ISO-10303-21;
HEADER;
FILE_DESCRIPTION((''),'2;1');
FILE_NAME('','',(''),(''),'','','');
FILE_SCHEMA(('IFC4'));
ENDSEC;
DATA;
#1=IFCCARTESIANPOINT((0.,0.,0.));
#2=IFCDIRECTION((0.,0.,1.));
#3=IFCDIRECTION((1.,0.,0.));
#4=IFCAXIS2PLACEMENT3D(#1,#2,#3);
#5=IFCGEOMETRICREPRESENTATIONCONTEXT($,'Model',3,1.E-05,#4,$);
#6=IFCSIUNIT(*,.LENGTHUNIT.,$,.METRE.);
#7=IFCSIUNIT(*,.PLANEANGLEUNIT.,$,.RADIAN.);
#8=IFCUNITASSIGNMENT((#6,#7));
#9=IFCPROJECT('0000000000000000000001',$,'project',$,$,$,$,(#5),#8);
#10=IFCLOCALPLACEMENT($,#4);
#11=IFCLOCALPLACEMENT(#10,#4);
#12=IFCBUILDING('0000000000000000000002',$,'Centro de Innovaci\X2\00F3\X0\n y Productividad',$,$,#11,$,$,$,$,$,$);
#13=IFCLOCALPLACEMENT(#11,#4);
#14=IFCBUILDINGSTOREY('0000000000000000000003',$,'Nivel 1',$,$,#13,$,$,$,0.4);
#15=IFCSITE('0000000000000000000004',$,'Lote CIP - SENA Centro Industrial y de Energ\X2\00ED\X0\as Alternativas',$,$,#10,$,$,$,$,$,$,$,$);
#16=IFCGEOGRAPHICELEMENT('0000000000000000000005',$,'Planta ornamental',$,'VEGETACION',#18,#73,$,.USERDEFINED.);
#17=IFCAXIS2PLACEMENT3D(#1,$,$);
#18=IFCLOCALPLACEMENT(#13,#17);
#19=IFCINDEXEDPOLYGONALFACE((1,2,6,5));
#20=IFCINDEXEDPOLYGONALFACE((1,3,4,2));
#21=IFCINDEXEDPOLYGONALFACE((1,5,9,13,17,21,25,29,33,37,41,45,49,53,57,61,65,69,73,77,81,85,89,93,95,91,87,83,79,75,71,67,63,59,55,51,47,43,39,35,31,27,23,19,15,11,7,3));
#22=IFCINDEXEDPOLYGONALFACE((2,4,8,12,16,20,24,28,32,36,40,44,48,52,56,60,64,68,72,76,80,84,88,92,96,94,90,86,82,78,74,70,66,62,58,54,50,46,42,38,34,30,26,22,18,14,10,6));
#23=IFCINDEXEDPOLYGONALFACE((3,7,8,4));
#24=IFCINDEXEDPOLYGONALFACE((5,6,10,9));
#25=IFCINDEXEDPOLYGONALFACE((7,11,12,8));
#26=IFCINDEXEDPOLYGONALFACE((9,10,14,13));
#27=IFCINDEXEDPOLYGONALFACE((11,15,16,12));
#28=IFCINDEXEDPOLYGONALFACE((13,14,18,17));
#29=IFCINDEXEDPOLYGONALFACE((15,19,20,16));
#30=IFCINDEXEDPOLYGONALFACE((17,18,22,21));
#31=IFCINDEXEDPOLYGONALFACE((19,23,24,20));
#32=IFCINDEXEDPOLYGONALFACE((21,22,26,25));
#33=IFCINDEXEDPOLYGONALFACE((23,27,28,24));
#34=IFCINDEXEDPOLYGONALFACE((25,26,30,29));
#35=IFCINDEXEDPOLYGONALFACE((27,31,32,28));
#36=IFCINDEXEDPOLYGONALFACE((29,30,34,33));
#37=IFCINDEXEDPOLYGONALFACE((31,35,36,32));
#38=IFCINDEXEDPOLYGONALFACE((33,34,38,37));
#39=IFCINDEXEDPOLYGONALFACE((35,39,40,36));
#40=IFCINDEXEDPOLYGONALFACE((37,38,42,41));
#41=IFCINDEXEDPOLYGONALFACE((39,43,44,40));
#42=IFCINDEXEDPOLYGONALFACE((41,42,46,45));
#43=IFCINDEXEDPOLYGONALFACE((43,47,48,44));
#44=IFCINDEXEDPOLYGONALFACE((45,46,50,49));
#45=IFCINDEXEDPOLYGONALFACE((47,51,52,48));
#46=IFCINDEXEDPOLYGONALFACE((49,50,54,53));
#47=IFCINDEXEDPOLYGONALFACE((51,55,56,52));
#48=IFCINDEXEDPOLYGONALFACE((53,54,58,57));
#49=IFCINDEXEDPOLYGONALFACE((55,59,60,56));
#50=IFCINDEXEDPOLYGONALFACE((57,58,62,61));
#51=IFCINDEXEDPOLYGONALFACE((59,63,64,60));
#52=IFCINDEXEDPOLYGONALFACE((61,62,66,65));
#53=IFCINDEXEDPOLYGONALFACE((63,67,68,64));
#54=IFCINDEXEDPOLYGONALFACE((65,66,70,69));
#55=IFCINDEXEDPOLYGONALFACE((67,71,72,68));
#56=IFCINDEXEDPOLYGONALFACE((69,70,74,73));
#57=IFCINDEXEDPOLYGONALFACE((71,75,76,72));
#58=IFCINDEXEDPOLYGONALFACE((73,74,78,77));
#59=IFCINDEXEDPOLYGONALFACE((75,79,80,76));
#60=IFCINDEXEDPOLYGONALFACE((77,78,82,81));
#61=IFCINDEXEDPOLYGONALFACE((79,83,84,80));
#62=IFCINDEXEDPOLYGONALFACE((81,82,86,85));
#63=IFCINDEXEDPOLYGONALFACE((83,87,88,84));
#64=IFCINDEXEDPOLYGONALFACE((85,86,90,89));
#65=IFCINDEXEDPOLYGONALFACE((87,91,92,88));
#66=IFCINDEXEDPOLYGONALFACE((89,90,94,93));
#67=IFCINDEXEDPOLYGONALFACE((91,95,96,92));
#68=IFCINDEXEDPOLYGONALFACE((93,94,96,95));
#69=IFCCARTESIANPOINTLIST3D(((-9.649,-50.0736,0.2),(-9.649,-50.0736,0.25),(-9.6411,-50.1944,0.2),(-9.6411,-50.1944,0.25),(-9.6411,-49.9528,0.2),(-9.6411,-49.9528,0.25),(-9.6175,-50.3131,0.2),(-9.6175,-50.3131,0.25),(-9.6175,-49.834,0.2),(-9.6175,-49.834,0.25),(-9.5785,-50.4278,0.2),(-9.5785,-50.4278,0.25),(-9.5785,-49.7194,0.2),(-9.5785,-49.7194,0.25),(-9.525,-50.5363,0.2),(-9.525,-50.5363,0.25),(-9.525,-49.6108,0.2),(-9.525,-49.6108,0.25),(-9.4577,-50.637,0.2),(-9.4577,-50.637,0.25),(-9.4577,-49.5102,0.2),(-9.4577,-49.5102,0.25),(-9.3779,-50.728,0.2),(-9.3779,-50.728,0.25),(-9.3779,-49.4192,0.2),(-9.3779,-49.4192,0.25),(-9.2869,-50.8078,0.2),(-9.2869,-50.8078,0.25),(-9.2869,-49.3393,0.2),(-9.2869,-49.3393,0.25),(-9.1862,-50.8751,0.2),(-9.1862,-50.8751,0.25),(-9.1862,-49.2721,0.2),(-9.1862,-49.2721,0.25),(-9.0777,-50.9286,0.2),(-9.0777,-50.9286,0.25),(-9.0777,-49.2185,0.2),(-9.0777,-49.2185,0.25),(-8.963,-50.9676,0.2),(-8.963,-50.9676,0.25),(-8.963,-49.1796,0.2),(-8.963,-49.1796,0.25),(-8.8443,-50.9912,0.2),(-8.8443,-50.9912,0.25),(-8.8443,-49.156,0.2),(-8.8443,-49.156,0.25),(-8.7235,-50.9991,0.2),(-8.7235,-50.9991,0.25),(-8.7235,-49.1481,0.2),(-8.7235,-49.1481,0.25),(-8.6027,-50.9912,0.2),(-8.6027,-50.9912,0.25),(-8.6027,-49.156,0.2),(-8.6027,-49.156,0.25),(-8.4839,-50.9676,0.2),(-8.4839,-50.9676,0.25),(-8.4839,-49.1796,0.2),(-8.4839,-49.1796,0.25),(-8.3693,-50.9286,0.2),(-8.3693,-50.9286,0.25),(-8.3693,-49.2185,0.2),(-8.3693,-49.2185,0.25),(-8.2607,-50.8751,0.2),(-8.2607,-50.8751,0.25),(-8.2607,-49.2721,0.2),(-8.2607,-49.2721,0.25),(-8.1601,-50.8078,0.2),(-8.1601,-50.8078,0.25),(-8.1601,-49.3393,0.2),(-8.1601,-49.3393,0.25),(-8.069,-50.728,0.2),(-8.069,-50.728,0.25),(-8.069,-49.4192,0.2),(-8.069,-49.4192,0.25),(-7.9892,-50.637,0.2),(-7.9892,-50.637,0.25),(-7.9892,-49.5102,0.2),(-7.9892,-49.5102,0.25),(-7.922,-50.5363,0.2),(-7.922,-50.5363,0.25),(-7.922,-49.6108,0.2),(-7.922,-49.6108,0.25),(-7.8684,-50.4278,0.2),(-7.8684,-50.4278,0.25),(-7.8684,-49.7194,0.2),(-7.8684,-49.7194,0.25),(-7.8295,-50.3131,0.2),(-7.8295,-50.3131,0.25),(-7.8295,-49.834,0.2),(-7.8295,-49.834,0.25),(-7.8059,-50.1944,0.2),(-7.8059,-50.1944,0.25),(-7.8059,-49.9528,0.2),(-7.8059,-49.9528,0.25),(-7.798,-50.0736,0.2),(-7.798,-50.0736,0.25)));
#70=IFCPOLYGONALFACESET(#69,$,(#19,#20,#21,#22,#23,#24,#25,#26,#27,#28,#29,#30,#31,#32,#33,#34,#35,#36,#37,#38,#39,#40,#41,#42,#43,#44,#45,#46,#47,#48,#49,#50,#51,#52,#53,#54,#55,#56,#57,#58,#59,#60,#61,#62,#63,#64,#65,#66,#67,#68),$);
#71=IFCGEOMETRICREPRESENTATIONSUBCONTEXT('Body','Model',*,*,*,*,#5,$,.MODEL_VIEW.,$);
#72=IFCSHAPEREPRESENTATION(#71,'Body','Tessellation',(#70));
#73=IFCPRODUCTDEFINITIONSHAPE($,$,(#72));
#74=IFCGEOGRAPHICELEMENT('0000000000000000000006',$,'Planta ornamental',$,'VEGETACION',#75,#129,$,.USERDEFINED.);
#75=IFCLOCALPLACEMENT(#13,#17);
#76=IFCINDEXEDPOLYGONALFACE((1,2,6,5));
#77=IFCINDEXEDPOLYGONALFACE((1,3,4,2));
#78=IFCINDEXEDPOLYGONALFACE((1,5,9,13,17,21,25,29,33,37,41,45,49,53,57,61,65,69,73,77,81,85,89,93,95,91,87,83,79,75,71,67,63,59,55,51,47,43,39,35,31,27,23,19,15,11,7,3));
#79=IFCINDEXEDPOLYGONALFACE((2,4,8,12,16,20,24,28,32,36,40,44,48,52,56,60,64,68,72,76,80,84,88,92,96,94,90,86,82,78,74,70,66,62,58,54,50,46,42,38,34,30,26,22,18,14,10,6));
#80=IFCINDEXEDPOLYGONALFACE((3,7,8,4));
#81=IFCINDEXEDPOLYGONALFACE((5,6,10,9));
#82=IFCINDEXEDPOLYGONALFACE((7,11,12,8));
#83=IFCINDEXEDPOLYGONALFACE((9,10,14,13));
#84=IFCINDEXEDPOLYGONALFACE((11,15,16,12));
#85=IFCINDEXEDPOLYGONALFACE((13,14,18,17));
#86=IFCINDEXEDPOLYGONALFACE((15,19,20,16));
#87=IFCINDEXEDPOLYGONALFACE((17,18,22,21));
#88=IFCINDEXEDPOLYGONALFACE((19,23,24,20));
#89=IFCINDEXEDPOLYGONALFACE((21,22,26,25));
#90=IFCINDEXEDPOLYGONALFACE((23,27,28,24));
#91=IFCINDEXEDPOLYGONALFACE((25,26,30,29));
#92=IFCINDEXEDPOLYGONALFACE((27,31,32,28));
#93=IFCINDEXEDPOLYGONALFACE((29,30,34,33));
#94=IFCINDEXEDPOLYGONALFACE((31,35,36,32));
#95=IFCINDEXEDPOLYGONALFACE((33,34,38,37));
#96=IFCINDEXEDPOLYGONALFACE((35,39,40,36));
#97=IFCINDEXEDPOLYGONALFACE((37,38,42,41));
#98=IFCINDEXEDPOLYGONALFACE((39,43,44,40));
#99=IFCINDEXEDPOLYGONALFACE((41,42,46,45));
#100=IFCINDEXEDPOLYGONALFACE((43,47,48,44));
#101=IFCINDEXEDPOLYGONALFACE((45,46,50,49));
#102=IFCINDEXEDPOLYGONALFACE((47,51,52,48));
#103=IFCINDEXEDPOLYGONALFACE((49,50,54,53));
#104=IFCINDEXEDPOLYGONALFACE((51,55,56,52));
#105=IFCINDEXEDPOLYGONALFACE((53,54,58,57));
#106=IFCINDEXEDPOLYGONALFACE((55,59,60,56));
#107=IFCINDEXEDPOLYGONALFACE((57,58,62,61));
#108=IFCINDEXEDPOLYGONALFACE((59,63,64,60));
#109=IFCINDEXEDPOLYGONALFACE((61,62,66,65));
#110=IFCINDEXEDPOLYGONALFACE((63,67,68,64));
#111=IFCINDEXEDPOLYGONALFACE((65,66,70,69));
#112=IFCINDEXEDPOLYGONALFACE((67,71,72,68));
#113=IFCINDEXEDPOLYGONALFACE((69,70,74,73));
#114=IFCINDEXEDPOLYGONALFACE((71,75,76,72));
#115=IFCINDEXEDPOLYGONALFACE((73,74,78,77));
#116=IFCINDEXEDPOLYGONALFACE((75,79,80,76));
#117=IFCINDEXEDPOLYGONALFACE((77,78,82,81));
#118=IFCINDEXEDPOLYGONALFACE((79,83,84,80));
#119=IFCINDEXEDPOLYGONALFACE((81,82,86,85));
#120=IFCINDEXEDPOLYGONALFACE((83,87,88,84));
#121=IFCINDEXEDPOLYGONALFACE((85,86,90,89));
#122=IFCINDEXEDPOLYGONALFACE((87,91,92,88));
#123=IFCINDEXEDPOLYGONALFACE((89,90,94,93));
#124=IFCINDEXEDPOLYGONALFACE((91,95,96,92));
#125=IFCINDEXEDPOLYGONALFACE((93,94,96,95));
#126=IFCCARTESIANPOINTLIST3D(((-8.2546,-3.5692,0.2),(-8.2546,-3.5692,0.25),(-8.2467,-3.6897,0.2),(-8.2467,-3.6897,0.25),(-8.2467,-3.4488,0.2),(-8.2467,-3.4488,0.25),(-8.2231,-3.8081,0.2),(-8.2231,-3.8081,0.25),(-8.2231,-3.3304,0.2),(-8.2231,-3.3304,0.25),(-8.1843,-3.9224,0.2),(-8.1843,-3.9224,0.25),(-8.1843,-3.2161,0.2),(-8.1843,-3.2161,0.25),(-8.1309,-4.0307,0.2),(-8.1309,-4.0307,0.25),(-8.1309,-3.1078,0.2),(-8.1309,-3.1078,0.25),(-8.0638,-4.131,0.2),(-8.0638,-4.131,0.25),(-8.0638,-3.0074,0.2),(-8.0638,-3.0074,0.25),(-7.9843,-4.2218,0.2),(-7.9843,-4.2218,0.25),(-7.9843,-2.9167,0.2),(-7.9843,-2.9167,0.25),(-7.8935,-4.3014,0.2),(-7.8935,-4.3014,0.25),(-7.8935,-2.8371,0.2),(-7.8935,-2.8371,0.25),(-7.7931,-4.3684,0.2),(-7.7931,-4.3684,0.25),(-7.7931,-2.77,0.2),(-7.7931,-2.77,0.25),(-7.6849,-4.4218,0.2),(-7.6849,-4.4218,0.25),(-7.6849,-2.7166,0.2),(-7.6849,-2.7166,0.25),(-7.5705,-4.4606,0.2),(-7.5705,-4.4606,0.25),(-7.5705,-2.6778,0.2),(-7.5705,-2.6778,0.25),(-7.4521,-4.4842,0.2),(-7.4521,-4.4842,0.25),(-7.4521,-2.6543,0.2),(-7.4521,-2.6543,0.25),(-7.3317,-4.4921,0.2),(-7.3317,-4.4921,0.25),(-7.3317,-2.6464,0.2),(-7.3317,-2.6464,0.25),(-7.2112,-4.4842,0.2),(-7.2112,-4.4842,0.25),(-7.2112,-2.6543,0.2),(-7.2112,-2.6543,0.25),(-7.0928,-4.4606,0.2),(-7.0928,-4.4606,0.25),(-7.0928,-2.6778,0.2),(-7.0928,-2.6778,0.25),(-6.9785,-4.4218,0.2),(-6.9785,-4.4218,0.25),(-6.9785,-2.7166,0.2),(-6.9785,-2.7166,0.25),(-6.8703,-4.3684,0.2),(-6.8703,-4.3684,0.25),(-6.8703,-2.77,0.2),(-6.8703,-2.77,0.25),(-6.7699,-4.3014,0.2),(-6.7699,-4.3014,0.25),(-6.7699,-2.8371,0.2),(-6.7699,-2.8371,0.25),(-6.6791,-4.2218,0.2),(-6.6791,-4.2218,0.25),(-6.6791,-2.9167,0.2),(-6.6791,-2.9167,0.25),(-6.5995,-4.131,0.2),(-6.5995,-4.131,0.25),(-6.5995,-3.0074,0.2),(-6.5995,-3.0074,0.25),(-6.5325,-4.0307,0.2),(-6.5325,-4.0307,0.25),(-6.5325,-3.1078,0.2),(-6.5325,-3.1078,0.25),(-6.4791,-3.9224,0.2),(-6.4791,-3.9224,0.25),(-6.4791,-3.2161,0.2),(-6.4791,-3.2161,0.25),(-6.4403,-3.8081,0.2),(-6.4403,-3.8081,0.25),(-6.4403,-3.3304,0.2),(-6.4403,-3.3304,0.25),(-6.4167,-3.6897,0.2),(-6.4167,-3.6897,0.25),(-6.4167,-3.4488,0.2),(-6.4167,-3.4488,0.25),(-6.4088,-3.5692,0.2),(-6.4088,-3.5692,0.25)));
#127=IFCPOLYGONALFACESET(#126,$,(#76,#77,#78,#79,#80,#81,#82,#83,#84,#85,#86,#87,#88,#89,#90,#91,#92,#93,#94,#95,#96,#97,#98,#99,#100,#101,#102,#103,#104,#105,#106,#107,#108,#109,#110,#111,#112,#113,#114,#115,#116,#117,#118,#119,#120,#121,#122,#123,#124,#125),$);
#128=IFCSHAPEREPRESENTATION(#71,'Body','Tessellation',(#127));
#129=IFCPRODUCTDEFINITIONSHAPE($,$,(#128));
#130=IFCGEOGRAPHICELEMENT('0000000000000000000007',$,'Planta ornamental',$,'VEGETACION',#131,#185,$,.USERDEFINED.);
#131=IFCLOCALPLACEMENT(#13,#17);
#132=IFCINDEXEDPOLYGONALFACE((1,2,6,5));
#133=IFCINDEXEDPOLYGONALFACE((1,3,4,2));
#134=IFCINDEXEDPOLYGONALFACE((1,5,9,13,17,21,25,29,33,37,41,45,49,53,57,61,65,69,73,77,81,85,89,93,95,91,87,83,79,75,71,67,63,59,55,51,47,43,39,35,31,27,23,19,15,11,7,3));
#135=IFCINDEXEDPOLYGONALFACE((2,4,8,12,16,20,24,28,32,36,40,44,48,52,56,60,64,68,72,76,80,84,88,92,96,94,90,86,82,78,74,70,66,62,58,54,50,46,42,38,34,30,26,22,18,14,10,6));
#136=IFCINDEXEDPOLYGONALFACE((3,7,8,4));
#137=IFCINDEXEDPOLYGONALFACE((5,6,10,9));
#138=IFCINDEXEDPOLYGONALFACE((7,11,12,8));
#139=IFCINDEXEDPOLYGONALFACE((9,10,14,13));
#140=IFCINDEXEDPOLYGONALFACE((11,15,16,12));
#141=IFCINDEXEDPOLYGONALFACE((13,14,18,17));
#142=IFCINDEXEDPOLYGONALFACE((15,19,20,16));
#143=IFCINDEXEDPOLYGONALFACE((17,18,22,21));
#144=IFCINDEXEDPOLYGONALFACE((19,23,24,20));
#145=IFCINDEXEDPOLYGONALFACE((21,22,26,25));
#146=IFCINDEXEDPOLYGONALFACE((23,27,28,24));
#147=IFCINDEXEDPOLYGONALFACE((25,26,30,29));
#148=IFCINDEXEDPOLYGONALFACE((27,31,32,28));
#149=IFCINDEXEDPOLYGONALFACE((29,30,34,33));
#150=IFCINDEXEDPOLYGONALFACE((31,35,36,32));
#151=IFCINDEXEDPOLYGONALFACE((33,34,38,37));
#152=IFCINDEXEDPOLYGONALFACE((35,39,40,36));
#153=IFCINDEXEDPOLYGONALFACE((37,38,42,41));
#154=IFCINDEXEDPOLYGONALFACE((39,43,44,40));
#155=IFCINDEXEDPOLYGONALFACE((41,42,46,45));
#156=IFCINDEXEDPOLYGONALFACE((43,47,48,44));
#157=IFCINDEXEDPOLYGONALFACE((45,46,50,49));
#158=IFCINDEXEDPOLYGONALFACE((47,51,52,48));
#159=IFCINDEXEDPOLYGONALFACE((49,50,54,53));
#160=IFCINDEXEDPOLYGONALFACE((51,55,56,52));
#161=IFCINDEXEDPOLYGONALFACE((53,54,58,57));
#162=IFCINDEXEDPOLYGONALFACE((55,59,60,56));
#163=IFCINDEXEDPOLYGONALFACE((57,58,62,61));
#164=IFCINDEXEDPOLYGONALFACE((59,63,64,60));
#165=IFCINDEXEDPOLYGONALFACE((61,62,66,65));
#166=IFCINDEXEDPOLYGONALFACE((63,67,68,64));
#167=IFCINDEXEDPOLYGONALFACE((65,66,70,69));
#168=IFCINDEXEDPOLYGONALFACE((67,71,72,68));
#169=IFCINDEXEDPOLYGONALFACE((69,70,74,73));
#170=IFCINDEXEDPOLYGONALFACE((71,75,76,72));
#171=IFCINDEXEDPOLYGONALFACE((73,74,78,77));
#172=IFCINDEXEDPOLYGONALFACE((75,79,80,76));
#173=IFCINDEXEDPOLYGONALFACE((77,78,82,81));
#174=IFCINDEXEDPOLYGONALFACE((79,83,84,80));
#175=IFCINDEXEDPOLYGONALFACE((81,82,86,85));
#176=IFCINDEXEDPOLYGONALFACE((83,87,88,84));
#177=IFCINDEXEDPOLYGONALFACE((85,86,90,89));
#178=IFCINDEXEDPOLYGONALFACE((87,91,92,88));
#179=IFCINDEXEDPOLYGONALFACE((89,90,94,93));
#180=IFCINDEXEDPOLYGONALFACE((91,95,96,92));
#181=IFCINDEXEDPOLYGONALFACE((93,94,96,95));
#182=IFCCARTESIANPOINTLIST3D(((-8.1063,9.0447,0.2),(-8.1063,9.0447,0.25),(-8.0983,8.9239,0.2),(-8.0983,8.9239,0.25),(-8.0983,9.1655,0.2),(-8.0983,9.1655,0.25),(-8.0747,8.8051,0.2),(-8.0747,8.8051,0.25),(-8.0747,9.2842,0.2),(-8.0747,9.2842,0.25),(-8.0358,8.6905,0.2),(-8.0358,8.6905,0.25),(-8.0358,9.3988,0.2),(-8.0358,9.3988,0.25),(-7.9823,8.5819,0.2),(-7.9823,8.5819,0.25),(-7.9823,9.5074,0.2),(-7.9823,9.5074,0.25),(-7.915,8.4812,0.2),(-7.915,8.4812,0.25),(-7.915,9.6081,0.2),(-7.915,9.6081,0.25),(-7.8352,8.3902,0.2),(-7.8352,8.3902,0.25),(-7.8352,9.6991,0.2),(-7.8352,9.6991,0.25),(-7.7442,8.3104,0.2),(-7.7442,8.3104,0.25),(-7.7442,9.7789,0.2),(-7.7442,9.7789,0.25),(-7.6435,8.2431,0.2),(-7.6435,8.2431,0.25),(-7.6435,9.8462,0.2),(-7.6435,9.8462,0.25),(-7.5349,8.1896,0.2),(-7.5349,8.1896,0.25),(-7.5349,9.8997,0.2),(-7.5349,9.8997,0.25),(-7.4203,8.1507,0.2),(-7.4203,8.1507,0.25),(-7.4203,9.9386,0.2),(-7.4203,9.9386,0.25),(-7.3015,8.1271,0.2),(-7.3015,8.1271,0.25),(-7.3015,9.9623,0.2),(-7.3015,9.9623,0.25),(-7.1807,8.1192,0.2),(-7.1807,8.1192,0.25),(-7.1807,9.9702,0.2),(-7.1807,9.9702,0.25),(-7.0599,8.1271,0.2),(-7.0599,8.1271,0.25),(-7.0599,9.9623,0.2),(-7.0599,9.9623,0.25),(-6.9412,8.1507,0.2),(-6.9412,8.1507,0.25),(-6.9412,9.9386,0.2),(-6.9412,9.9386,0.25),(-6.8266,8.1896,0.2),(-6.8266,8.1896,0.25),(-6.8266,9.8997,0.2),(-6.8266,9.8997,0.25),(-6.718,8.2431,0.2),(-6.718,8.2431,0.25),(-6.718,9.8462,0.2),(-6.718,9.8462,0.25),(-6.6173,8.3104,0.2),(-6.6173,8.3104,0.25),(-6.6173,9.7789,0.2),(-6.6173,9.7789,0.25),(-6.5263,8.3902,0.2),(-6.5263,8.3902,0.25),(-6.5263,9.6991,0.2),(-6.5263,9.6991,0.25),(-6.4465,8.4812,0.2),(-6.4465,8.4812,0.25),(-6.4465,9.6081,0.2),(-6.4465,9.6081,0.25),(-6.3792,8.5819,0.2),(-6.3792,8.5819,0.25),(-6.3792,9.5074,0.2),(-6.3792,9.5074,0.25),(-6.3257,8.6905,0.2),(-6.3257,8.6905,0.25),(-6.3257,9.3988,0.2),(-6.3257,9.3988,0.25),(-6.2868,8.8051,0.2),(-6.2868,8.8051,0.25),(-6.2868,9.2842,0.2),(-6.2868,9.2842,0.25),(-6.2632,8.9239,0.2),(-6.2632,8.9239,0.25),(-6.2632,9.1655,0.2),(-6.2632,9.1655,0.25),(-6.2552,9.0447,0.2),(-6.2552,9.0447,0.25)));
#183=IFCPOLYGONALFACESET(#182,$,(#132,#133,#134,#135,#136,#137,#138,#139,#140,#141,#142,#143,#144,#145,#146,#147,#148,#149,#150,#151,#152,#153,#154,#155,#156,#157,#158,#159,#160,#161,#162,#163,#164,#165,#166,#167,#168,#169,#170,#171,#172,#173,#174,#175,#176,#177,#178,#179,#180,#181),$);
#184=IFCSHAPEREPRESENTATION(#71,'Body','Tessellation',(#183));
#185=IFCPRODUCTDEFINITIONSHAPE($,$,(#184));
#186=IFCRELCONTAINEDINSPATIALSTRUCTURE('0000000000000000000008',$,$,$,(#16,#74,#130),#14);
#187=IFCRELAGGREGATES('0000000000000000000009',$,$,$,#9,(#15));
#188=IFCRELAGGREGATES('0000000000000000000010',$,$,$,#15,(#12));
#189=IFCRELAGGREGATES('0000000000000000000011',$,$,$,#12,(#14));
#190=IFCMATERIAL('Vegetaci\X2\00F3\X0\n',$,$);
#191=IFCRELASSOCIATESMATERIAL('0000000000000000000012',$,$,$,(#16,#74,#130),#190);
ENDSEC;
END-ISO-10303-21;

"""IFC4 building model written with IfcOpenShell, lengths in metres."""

from ifc_helpers import new_model, si_unit, frame, origin_with_axes, place, context, subcontext, project, spatial, polyline, outline, extrude, material, element, save


model = new_model("IFC4")

# Units and contexts
model_context = context("Model", 3, precision=1e-05, world=origin_with_axes())
body_context = subcontext(model_context, "Body", "Model", "MODEL_VIEW")
ifc_project = project(units=[si_unit("LENGTHUNIT", "METRE"), si_unit("PLANEANGLEUNIT", "RADIAN")], contexts=[model_context])

# Site, building, storey
site_placement = place(None, origin_with_axes())
site = spatial("IfcSite", under=ifc_project, at=site_placement, Name="Lote CIP - SENA Centro Industrial y de Energías Alternativas")
building_placement = place(site_placement, origin_with_axes())
building = spatial("IfcBuilding", under=site, at=building_placement, Name="Centro de Innovación y Productividad")
storey_placement = place(building_placement, origin_with_axes())
storey = spatial("IfcBuildingStorey", under=building, at=storey_placement, Name="Nivel 1", Elevation=0.4)

# Geographic elements
ifc_material = material(Name="Vegetación")
geographic_element_1_placement = place(storey_placement, origin_with_axes())
element("IfcGeographicElement", 1, at=geographic_element_1_placement, inside=storey, material=ifc_material, Name="Planta ornamental", ObjectType="VEGETACION", PredefinedType="USERDEFINED", context=body_context, shape_type="SweptSolid", body=[
    extrude(outline(polyline([(-7.798, -50.0736), (-7.8059, -50.1944), (-7.8295, -50.3131), (-7.8684, -50.4278), (-7.922, -50.5363), (-7.9892, -50.637), (-8.069, -50.728), (-8.1601, -50.8078), (-8.2607, -50.8751), (-8.3693, -50.9286), (-8.4839, -50.9676), (-8.6027, -50.9912), (-8.7235, -50.9991), (-8.8443, -50.9912), (-8.963, -50.9676), (-9.0777, -50.9286), (-9.1862, -50.8751), (-9.2869, -50.8078), (-9.3779, -50.728), (-9.4577, -50.637), (-9.525, -50.5363), (-9.5785, -50.4278), (-9.6175, -50.3131), (-9.6411, -50.1944), (-9.649, -50.0736), (-9.6411, -49.9528), (-9.6175, -49.834), (-9.5785, -49.7194), (-9.525, -49.6108), (-9.4577, -49.5102), (-9.3779, -49.4192), (-9.2869, -49.3393), (-9.1862, -49.2721), (-9.0777, -49.2185), (-8.963, -49.1796), (-8.8443, -49.156), (-8.7235, -49.1481), (-8.6027, -49.156), (-8.4839, -49.1796), (-8.3693, -49.2185), (-8.2607, -49.2721), (-8.1601, -49.3393), (-8.069, -49.4192), (-7.9892, -49.5102), (-7.922, -49.6108), (-7.8684, -49.7194), (-7.8295, -49.834), (-7.8059, -49.9528), (-7.798, -50.0736)])), frame((0.0, 0.0, 0.2)), (0.0, 0.0, 1.0), 0.05),
])
geographic_element_2_placement = place(storey_placement, origin_with_axes())
element("IfcGeographicElement", 2, at=geographic_element_2_placement, inside=storey, material=ifc_material, Name="Planta ornamental", ObjectType="VEGETACION", PredefinedType="USERDEFINED", context=body_context, shape_type="SweptSolid", body=[
    extrude(outline(polyline([(-6.4088, -3.5692), (-6.4167, -3.6897), (-6.4403, -3.8081), (-6.4791, -3.9224), (-6.5325, -4.0307), (-6.5995, -4.131), (-6.6791, -4.2218), (-6.7699, -4.3014), (-6.8703, -4.3684), (-6.9785, -4.4218), (-7.0928, -4.4606), (-7.2112, -4.4842), (-7.3317, -4.4921), (-7.4521, -4.4842), (-7.5705, -4.4606), (-7.6849, -4.4218), (-7.7931, -4.3684), (-7.8935, -4.3014), (-7.9843, -4.2218), (-8.0638, -4.131), (-8.1309, -4.0307), (-8.1843, -3.9224), (-8.2231, -3.8081), (-8.2467, -3.6897), (-8.2546, -3.5692), (-8.2467, -3.4488), (-8.2231, -3.3304), (-8.1843, -3.2161), (-8.1309, -3.1078), (-8.0638, -3.0074), (-7.9843, -2.9167), (-7.8935, -2.8371), (-7.7931, -2.77), (-7.6849, -2.7166), (-7.5705, -2.6778), (-7.4521, -2.6543), (-7.3317, -2.6464), (-7.2112, -2.6543), (-7.0928, -2.6778), (-6.9785, -2.7166), (-6.8703, -2.77), (-6.7699, -2.8371), (-6.6791, -2.9167), (-6.5995, -3.0074), (-6.5325, -3.1078), (-6.4791, -3.2161), (-6.4403, -3.3304), (-6.4167, -3.4488), (-6.4088, -3.5692)])), frame((0.0, 0.0, 0.2)), (0.0, 0.0, 1.0), 0.05),
])
geographic_element_3_placement = place(storey_placement, origin_with_axes())
element("IfcGeographicElement", 3, at=geographic_element_3_placement, inside=storey, material=ifc_material, Name="Planta ornamental", ObjectType="VEGETACION", PredefinedType="USERDEFINED", context=body_context, shape_type="SweptSolid", body=[
    extrude(outline(polyline([(-6.2552, 9.0447), (-6.2632, 8.9239), (-6.2868, 8.8051), (-6.3257, 8.6905), (-6.3792, 8.5819), (-6.4465, 8.4812), (-6.5263, 8.3902), (-6.6173, 8.3104), (-6.718, 8.2431), (-6.8266, 8.1896), (-6.9412, 8.1507), (-7.0599, 8.1271), (-7.1807, 8.1192), (-7.3015, 8.1271), (-7.4203, 8.1507), (-7.5349, 8.1896), (-7.6435, 8.2431), (-7.7442, 8.3104), (-7.8352, 8.3902), (-7.915, 8.4812), (-7.9823, 8.5819), (-8.0358, 8.6905), (-8.0747, 8.8051), (-8.0983, 8.9239), (-8.1063, 9.0447), (-8.0983, 9.1655), (-8.0747, 9.2842), (-8.0358, 9.3988), (-7.9823, 9.5074), (-7.915, 9.6081), (-7.8352, 9.6991), (-7.7442, 9.7789), (-7.6435, 9.8462), (-7.5349, 9.8997), (-7.4203, 9.9386), (-7.3015, 9.9623), (-7.1807, 9.9702), (-7.0599, 9.9623), (-6.9412, 9.9386), (-6.8266, 9.8997), (-6.718, 9.8462), (-6.6173, 9.7789), (-6.5263, 9.6991), (-6.4465, 9.6081), (-6.3792, 9.5074), (-6.3257, 9.3988), (-6.2868, 9.2842), (-6.2632, 9.1655), (-6.2552, 9.0447)])), frame((0.0, 0.0, 0.2)), (0.0, 0.0, 1.0), 0.05),
])

save(model, "model.ifc")
